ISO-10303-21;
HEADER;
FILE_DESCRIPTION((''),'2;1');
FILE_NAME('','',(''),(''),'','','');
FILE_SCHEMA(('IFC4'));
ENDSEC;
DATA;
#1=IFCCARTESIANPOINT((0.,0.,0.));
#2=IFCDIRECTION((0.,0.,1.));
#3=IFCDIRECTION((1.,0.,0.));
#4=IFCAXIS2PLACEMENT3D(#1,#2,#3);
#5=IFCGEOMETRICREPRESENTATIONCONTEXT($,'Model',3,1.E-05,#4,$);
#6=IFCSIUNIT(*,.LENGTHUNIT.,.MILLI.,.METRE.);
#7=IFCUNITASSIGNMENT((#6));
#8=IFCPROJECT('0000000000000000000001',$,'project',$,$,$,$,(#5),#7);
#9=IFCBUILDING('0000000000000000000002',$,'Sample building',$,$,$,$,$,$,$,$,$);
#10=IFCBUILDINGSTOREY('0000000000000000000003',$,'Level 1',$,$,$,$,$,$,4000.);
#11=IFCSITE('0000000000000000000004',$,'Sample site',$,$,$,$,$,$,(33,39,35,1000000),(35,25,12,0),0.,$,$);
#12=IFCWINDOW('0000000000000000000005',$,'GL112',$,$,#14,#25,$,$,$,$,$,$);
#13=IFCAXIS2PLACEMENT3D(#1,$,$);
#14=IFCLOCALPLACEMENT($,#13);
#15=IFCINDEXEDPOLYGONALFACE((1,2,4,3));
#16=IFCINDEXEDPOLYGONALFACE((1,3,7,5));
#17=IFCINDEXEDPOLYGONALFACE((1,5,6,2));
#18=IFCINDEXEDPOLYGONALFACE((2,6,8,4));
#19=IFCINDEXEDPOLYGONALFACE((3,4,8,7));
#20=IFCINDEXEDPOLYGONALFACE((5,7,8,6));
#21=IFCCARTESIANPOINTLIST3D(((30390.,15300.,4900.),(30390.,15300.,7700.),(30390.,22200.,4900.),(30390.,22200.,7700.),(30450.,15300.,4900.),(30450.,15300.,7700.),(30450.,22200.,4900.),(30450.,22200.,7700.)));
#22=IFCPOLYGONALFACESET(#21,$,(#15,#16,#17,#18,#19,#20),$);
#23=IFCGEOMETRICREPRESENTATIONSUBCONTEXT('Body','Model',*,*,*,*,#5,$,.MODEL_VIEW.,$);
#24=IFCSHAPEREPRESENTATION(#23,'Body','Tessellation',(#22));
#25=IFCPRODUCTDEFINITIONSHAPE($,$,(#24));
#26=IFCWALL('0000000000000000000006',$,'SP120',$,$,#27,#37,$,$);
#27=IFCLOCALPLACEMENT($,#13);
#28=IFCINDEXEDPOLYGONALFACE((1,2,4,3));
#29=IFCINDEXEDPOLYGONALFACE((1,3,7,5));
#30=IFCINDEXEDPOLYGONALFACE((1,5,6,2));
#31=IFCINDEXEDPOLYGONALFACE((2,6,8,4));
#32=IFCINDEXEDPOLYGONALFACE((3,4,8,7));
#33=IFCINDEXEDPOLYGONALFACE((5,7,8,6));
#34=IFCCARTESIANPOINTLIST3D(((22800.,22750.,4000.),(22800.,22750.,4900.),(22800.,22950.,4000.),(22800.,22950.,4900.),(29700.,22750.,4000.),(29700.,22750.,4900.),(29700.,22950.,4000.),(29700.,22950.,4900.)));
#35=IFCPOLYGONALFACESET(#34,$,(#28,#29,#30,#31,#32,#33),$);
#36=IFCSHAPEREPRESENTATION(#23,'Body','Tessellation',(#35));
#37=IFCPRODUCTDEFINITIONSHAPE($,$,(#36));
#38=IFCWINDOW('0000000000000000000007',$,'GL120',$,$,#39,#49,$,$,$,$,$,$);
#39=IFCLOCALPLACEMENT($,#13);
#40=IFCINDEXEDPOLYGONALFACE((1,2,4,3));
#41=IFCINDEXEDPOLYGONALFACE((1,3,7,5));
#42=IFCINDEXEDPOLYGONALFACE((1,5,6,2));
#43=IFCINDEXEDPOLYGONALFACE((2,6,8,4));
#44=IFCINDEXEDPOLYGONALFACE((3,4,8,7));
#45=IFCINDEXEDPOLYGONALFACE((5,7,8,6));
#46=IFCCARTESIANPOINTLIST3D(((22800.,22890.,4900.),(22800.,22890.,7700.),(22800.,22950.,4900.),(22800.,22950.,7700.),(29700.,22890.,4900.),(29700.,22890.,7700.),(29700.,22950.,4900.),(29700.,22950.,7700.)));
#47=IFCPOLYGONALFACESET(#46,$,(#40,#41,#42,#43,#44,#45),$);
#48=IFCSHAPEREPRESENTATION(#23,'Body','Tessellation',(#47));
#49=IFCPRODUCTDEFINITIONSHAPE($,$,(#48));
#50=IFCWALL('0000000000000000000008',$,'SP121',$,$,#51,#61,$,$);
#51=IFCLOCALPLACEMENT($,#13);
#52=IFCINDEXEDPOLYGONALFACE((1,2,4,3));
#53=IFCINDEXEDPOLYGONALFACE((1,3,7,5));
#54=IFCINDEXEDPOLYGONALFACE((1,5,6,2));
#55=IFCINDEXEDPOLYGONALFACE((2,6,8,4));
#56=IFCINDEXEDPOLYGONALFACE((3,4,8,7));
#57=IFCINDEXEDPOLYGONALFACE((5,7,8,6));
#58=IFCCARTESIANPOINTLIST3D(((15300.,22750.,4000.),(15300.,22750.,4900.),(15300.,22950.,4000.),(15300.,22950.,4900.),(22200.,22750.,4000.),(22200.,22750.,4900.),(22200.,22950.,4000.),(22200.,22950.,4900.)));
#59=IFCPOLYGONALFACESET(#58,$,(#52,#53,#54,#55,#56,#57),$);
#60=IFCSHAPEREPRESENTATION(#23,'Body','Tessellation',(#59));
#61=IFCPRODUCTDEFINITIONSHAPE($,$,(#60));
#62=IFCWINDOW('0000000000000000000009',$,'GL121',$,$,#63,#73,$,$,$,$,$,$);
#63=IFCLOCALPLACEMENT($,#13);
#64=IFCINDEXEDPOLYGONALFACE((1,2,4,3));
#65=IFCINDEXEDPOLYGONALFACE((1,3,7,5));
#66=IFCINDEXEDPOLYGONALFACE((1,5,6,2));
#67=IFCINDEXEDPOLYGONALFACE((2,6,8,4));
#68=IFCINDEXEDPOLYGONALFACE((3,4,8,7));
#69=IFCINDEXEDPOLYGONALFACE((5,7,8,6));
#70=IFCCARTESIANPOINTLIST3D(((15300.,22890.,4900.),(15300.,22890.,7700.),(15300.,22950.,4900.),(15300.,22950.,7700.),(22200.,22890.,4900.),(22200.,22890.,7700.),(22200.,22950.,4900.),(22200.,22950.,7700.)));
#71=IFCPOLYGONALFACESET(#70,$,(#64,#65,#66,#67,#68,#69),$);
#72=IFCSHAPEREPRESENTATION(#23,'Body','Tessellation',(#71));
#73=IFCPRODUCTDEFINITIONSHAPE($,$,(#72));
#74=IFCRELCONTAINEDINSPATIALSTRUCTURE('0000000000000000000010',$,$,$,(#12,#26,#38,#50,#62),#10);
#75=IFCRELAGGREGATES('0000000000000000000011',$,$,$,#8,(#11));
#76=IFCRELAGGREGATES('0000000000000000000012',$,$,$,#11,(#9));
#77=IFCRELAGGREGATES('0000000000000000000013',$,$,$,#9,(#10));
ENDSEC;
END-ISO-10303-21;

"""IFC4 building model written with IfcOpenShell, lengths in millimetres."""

from ifc_helpers import new_model, si_unit, frame, origin_with_axes, place, context, subcontext, project, spatial, indexed_curve, outline, extrude, element, save


model = new_model("IFC4")

# Units and contexts
model_context = context("Model", 3, precision=1e-05, world=origin_with_axes())
body_context = subcontext(model_context, "Body", "Model", "MODEL_VIEW")
ifc_project = project(units=[si_unit("LENGTHUNIT", "METRE", prefix="MILLI")], contexts=[model_context])

# Site, building, storey
site = spatial("IfcSite", under=ifc_project, Name="Sample site", RefLatitude=(33, 39, 35, 1000000), RefLongitude=(35, 25, 12, 0), RefElevation=0.0)
building = spatial("IfcBuilding", under=site, Name="Sample building")
storey = spatial("IfcBuildingStorey", under=building, Name="Level 1", Elevation=4000.0)

# Window
window_1_placement = place(None, frame((30450.0, 15300.0, 4900.0), z_axis=(0.0, 0.0, 1.0), x_axis=(0.0, 1.0, 0.0)))
element("IfcWindow", 1, at=window_1_placement, inside=storey, Name="GL112", context=body_context, shape_type="SweptSolid", body=[
    extrude(outline(indexed_curve([(0.0, 0.0), (0.0, 60.0), (6900.0, 60.0), (6900.0, 0.0), (0.0, 0.0)], self_intersect=False)), origin_with_axes(), (0.0, 0.0, 1.0), 2800.0),
])

# Wall
wall_1_placement = place(None, frame((29700.0, 22950.0, 4000.0), z_axis=(0.0, 0.0, 1.0), x_axis=(-1.0, 0.0, 0.0)))
element("IfcWall", 2, at=wall_1_placement, inside=storey, Name="SP120", context=body_context, shape_type="SweptSolid", body=[
    extrude(outline(indexed_curve([(0.0, 0.0), (0.0, 200.0), (6900.0, 200.0), (6900.0, 0.0), (0.0, 0.0)], self_intersect=False)), origin_with_axes(), (0.0, 0.0, 1.0), 900.0),
])

# Window
window_2_placement = place(None, frame((29700.0, 22950.0, 4900.0), z_axis=(0.0, 0.0, 1.0), x_axis=(-1.0, 0.0, 0.0)))
element("IfcWindow", 3, at=window_2_placement, inside=storey, Name="GL120", context=body_context, shape_type="SweptSolid", body=[
    extrude(outline(indexed_curve([(0.0, 0.0), (0.0, 60.0), (6900.0, 60.0), (6900.0, 0.0), (0.0, 0.0)], self_intersect=False)), origin_with_axes(), (0.0, 0.0, 1.0), 2800.0),
])

# Wall
wall_2_placement = place(None, frame((22200.0, 22950.0, 4000.0), z_axis=(0.0, 0.0, 1.0), x_axis=(-1.0, 0.0, 0.0)))
element("IfcWall", 4, at=wall_2_placement, inside=storey, Name="SP121", context=body_context, shape_type="SweptSolid", body=[
    extrude(outline(indexed_curve([(0.0, 0.0), (0.0, 200.0), (6900.0, 200.0), (6900.0, 0.0), (0.0, 0.0)], self_intersect=False)), origin_with_axes(), (0.0, 0.0, 1.0), 900.0),
])

# Window
window_3_placement = place(None, frame((22200.0, 22950.0, 4900.0), z_axis=(0.0, 0.0, 1.0), x_axis=(-1.0, 0.0, 0.0)))
element("IfcWindow", 5, at=window_3_placement, inside=storey, Name="GL121", context=body_context, shape_type="SweptSolid", body=[
    extrude(outline(indexed_curve([(0.0, 0.0), (0.0, 60.0), (6900.0, 60.0), (6900.0, 0.0), (0.0, 0.0)], self_intersect=False)), origin_with_axes(), (0.0, 0.0, 1.0), 2800.0),
])

save(model, "model.ifc")
